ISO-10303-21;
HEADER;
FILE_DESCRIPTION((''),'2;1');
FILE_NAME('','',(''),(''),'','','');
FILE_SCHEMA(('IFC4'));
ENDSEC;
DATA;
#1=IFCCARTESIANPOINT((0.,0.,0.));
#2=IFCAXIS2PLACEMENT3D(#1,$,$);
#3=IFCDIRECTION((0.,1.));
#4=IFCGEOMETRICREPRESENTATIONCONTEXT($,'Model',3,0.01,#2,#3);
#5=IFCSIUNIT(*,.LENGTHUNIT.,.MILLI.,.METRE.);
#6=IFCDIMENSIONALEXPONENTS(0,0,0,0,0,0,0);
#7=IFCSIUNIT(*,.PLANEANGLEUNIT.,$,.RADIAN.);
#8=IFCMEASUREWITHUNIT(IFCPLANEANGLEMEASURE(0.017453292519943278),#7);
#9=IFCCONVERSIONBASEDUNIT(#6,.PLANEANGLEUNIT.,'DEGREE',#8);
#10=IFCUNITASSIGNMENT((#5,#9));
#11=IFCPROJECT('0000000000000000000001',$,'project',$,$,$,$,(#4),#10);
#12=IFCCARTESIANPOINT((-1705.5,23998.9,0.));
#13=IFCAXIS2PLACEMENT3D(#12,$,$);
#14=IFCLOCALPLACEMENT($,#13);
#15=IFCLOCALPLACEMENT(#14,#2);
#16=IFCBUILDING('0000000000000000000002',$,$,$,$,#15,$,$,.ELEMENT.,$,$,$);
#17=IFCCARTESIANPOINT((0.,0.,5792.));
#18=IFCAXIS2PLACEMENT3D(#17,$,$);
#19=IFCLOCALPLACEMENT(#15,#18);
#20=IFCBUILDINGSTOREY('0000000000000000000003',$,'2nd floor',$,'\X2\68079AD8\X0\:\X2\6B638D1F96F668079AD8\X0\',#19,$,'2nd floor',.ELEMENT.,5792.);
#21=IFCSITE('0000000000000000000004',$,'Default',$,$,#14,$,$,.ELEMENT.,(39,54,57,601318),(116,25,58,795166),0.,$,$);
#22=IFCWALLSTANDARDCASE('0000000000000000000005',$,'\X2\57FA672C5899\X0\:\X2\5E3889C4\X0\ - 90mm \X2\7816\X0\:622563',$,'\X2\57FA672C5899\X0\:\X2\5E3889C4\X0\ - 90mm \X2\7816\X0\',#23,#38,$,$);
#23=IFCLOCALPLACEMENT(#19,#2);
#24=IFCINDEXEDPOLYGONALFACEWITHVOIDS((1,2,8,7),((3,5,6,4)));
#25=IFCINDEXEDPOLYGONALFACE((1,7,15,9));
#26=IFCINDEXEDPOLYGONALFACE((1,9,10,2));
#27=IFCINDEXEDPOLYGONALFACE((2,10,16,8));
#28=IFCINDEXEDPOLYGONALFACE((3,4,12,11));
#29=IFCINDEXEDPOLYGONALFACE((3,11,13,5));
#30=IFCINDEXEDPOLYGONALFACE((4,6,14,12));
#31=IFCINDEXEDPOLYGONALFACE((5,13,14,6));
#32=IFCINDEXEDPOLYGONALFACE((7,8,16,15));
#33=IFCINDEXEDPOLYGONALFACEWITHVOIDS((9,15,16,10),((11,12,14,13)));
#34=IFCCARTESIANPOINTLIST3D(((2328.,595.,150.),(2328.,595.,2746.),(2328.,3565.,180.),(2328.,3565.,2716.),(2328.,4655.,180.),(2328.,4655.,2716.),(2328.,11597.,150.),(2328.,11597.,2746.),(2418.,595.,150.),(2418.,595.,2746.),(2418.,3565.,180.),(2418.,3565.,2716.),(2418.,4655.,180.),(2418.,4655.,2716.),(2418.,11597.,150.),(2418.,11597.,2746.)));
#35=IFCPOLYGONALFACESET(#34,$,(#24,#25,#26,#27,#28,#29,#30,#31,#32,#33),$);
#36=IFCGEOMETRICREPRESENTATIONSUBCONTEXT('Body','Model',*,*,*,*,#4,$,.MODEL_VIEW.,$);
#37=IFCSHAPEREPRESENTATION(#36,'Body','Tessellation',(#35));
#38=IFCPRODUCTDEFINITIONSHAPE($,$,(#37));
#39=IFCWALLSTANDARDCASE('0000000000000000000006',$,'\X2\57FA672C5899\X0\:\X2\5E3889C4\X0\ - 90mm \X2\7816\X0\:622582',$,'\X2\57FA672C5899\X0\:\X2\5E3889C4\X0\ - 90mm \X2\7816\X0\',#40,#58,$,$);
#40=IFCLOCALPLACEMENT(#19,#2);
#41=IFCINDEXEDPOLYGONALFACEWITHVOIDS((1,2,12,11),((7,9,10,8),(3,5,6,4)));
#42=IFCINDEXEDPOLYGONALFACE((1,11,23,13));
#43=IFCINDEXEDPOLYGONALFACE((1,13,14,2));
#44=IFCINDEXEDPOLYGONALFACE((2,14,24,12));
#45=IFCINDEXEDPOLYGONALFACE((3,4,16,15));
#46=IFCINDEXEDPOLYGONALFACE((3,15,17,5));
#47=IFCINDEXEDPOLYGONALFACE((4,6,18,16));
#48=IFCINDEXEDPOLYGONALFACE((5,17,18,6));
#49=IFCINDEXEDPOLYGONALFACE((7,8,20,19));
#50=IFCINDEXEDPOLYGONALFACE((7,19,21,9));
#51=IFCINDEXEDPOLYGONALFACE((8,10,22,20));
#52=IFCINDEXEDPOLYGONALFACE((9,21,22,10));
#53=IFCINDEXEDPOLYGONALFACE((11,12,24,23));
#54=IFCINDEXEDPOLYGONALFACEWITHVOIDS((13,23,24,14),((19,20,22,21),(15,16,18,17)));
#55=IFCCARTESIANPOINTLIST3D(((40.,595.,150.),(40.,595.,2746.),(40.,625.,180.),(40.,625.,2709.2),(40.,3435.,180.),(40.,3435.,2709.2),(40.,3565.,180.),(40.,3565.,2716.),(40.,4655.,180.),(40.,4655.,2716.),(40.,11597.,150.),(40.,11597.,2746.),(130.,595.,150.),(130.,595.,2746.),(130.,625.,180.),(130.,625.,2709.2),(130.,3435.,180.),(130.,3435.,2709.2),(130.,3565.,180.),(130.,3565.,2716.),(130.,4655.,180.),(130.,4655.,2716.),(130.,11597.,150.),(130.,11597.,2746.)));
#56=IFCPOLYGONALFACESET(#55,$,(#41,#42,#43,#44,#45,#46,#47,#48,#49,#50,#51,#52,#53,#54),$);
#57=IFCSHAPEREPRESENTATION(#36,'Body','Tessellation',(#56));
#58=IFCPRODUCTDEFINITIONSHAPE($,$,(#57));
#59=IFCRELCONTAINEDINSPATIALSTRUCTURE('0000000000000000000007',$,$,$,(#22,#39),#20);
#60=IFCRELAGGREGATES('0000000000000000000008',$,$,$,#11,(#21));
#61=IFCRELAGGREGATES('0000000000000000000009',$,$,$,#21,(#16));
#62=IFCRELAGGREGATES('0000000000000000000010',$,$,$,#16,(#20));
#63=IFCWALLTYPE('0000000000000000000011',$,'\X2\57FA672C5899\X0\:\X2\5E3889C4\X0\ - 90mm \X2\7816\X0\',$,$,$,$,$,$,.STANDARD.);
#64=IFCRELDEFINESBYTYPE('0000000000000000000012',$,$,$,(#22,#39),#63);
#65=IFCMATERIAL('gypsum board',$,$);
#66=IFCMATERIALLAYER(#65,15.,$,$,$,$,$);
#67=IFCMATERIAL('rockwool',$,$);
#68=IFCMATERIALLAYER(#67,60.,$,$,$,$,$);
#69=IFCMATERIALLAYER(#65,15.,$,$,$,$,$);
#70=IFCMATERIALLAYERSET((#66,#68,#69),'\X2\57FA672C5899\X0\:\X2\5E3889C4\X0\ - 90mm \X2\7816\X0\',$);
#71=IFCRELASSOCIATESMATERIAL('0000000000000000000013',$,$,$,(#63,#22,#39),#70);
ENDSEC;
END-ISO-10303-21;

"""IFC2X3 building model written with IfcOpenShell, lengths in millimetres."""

from ifc_helpers import new_model, entity, si_unit, converted_unit, direction, frame, frame_2d, origin, place, context, subcontext, project, spatial, rectangle, extrude, material, layer, layer_set, layer_usage, type_object, element, save


model = new_model("IFC2X3")

# Units and contexts
model_context = context("Model", 3, precision=0.01, world=origin(), true_north=direction((0.0, 1.0)))
body_context = subcontext(model_context, "Body", "Model", "MODEL_VIEW")
ifc_project = project(units=[si_unit("LENGTHUNIT", "METRE", prefix="MILLI"), converted_unit("PLANEANGLEUNIT", "DEGREE", entity("IfcPlaneAngleMeasure", 0.017453292519943278), si_unit("PLANEANGLEUNIT", "RADIAN"), dimensions=[0, 0, 0, 0, 0, 0, 0])], contexts=[model_context])

# Site, building, storey
site_placement = place(None, frame((-1705.5, 23998.9, 0.0)))
site = spatial("IfcSite", under=ifc_project, at=site_placement, Name="Default", CompositionType="ELEMENT", RefLatitude=(39, 54, 57, 601318), RefLongitude=(116, 25, 58, 795166), RefElevation=0.0)
building_placement = place(site_placement, origin())
building = spatial("IfcBuilding", under=site, at=building_placement, CompositionType="ELEMENT")
storey_placement = place(building_placement, frame((0.0, 0.0, 5792.0)))
storey = spatial("IfcBuildingStorey", under=building, at=storey_placement, Name="2nd floor", ObjectType="标高:正负零标高", LongName="2nd floor", CompositionType="ELEMENT", Elevation=5792.0)

# Shared definitions
ifc_material_1 = material(Name="gypsum board")
ifc_layer_1 = layer(ifc_material_1, 15.0)
ifc_material_2 = material(Name="rockwool")
ifc_layer_2 = layer(ifc_material_2, 60.0)
ifc_layer_3 = layer(ifc_material_1, 15.0)
ifc_layer_set = layer_set([ifc_layer_1, ifc_layer_2, ifc_layer_3], Name="基本墙:常规 - 90mm 砖")
wall_type = type_object("IfcWallType", Name="基本墙:常规 - 90mm 砖", PredefinedType="STANDARD", material=ifc_layer_set)

# Wall, opening
ifc_layer_usage_1 = layer_usage(ifc_layer_set, "AXIS2", "NEGATIVE", 45.0)
wall_1_placement = place(storey_placement, frame((2373.0, 11597.0, 150.0), z_axis=(0.0, 0.0, 1.0), x_axis=(0.0, -1.0, 0.0)))
wall_1 = element("IfcWallStandardCase", 1, at=wall_1_placement, inside=storey, type_object=wall_type, material=ifc_layer_usage_1, Name="基本墙:常规 - 90mm 砖:622563", ObjectType="基本墙:常规 - 90mm 砖", context=body_context, shape_type="SweptSolid", body=[
    extrude(rectangle(XDim=11002.0, YDim=90.0, at=frame_2d((5501.0, 0.0), x_axis=(-1.0, 0.0))), origin(), (0.0, 0.0, 1.0), 2596.0),
])
opening_1_placement = place(wall_1_placement, origin())
element("IfcOpeningElement", 2, at=opening_1_placement, cuts=wall_1, ObjectType="Opening", context=body_context, shape_type="SweptSolid", body=[
    extrude(rectangle(XDim=2536.0, YDim=1090.0, at=frame_2d((0.0, 0.0), x_axis=(0.0, 1.0))), frame((7487.0, 45.0, 1298.0), z_axis=(0.0, -1.0, 0.0), x_axis=(-1.0, 0.0, 0.0)), (0.0, 0.0, 1.0), 90.0),
])

# Wall, openings
ifc_layer_usage_2 = layer_usage(ifc_layer_set, "AXIS2", "NEGATIVE", 45.0)
wall_2_placement = place(storey_placement, frame((85.0, 11597.0, 150.0), z_axis=(0.0, 0.0, 1.0), x_axis=(0.0, -1.0, 0.0)))
wall_2 = element("IfcWallStandardCase", 3, at=wall_2_placement, inside=storey, type_object=wall_type, material=ifc_layer_usage_2, Name="基本墙:常规 - 90mm 砖:622582", ObjectType="基本墙:常规 - 90mm 砖", context=body_context, shape_type="SweptSolid", body=[
    extrude(rectangle(XDim=11002.0, YDim=90.0, at=frame_2d((5501.0, 0.0), x_axis=(-1.0, 0.0))), origin(), (0.0, 0.0, 1.0), 2596.0),
])
opening_2_placement = place(wall_2_placement, origin())
element("IfcOpeningElement", 4, at=opening_2_placement, cuts=wall_2, ObjectType="Opening", context=body_context, shape_type="SweptSolid", body=[
    extrude(rectangle(XDim=2536.0, YDim=1090.0, at=frame_2d((0.0, 0.0), x_axis=(0.0, 1.0))), frame((7487.0, 45.0, 1298.0), z_axis=(0.0, -1.0, 0.0), x_axis=(-1.0, 0.0, 0.0)), (0.0, 0.0, 1.0), 90.0),
])
opening_3_placement = place(wall_2_placement, origin())
element("IfcOpeningElement", 5, at=opening_3_placement, cuts=wall_2, ObjectType="Opening", context=body_context, shape_type="SweptSolid", body=[
    extrude(rectangle(XDim=2529.2, YDim=2810.0, at=frame_2d((0.0, 0.0), x_axis=(0.0, 1.0))), frame((9567.0, 45.0, 1294.6), z_axis=(0.0, -1.0, 0.0), x_axis=(-1.0, 0.0, 0.0)), (0.0, 0.0, 1.0), 90.0),
])

save(model, "model.ifc")
